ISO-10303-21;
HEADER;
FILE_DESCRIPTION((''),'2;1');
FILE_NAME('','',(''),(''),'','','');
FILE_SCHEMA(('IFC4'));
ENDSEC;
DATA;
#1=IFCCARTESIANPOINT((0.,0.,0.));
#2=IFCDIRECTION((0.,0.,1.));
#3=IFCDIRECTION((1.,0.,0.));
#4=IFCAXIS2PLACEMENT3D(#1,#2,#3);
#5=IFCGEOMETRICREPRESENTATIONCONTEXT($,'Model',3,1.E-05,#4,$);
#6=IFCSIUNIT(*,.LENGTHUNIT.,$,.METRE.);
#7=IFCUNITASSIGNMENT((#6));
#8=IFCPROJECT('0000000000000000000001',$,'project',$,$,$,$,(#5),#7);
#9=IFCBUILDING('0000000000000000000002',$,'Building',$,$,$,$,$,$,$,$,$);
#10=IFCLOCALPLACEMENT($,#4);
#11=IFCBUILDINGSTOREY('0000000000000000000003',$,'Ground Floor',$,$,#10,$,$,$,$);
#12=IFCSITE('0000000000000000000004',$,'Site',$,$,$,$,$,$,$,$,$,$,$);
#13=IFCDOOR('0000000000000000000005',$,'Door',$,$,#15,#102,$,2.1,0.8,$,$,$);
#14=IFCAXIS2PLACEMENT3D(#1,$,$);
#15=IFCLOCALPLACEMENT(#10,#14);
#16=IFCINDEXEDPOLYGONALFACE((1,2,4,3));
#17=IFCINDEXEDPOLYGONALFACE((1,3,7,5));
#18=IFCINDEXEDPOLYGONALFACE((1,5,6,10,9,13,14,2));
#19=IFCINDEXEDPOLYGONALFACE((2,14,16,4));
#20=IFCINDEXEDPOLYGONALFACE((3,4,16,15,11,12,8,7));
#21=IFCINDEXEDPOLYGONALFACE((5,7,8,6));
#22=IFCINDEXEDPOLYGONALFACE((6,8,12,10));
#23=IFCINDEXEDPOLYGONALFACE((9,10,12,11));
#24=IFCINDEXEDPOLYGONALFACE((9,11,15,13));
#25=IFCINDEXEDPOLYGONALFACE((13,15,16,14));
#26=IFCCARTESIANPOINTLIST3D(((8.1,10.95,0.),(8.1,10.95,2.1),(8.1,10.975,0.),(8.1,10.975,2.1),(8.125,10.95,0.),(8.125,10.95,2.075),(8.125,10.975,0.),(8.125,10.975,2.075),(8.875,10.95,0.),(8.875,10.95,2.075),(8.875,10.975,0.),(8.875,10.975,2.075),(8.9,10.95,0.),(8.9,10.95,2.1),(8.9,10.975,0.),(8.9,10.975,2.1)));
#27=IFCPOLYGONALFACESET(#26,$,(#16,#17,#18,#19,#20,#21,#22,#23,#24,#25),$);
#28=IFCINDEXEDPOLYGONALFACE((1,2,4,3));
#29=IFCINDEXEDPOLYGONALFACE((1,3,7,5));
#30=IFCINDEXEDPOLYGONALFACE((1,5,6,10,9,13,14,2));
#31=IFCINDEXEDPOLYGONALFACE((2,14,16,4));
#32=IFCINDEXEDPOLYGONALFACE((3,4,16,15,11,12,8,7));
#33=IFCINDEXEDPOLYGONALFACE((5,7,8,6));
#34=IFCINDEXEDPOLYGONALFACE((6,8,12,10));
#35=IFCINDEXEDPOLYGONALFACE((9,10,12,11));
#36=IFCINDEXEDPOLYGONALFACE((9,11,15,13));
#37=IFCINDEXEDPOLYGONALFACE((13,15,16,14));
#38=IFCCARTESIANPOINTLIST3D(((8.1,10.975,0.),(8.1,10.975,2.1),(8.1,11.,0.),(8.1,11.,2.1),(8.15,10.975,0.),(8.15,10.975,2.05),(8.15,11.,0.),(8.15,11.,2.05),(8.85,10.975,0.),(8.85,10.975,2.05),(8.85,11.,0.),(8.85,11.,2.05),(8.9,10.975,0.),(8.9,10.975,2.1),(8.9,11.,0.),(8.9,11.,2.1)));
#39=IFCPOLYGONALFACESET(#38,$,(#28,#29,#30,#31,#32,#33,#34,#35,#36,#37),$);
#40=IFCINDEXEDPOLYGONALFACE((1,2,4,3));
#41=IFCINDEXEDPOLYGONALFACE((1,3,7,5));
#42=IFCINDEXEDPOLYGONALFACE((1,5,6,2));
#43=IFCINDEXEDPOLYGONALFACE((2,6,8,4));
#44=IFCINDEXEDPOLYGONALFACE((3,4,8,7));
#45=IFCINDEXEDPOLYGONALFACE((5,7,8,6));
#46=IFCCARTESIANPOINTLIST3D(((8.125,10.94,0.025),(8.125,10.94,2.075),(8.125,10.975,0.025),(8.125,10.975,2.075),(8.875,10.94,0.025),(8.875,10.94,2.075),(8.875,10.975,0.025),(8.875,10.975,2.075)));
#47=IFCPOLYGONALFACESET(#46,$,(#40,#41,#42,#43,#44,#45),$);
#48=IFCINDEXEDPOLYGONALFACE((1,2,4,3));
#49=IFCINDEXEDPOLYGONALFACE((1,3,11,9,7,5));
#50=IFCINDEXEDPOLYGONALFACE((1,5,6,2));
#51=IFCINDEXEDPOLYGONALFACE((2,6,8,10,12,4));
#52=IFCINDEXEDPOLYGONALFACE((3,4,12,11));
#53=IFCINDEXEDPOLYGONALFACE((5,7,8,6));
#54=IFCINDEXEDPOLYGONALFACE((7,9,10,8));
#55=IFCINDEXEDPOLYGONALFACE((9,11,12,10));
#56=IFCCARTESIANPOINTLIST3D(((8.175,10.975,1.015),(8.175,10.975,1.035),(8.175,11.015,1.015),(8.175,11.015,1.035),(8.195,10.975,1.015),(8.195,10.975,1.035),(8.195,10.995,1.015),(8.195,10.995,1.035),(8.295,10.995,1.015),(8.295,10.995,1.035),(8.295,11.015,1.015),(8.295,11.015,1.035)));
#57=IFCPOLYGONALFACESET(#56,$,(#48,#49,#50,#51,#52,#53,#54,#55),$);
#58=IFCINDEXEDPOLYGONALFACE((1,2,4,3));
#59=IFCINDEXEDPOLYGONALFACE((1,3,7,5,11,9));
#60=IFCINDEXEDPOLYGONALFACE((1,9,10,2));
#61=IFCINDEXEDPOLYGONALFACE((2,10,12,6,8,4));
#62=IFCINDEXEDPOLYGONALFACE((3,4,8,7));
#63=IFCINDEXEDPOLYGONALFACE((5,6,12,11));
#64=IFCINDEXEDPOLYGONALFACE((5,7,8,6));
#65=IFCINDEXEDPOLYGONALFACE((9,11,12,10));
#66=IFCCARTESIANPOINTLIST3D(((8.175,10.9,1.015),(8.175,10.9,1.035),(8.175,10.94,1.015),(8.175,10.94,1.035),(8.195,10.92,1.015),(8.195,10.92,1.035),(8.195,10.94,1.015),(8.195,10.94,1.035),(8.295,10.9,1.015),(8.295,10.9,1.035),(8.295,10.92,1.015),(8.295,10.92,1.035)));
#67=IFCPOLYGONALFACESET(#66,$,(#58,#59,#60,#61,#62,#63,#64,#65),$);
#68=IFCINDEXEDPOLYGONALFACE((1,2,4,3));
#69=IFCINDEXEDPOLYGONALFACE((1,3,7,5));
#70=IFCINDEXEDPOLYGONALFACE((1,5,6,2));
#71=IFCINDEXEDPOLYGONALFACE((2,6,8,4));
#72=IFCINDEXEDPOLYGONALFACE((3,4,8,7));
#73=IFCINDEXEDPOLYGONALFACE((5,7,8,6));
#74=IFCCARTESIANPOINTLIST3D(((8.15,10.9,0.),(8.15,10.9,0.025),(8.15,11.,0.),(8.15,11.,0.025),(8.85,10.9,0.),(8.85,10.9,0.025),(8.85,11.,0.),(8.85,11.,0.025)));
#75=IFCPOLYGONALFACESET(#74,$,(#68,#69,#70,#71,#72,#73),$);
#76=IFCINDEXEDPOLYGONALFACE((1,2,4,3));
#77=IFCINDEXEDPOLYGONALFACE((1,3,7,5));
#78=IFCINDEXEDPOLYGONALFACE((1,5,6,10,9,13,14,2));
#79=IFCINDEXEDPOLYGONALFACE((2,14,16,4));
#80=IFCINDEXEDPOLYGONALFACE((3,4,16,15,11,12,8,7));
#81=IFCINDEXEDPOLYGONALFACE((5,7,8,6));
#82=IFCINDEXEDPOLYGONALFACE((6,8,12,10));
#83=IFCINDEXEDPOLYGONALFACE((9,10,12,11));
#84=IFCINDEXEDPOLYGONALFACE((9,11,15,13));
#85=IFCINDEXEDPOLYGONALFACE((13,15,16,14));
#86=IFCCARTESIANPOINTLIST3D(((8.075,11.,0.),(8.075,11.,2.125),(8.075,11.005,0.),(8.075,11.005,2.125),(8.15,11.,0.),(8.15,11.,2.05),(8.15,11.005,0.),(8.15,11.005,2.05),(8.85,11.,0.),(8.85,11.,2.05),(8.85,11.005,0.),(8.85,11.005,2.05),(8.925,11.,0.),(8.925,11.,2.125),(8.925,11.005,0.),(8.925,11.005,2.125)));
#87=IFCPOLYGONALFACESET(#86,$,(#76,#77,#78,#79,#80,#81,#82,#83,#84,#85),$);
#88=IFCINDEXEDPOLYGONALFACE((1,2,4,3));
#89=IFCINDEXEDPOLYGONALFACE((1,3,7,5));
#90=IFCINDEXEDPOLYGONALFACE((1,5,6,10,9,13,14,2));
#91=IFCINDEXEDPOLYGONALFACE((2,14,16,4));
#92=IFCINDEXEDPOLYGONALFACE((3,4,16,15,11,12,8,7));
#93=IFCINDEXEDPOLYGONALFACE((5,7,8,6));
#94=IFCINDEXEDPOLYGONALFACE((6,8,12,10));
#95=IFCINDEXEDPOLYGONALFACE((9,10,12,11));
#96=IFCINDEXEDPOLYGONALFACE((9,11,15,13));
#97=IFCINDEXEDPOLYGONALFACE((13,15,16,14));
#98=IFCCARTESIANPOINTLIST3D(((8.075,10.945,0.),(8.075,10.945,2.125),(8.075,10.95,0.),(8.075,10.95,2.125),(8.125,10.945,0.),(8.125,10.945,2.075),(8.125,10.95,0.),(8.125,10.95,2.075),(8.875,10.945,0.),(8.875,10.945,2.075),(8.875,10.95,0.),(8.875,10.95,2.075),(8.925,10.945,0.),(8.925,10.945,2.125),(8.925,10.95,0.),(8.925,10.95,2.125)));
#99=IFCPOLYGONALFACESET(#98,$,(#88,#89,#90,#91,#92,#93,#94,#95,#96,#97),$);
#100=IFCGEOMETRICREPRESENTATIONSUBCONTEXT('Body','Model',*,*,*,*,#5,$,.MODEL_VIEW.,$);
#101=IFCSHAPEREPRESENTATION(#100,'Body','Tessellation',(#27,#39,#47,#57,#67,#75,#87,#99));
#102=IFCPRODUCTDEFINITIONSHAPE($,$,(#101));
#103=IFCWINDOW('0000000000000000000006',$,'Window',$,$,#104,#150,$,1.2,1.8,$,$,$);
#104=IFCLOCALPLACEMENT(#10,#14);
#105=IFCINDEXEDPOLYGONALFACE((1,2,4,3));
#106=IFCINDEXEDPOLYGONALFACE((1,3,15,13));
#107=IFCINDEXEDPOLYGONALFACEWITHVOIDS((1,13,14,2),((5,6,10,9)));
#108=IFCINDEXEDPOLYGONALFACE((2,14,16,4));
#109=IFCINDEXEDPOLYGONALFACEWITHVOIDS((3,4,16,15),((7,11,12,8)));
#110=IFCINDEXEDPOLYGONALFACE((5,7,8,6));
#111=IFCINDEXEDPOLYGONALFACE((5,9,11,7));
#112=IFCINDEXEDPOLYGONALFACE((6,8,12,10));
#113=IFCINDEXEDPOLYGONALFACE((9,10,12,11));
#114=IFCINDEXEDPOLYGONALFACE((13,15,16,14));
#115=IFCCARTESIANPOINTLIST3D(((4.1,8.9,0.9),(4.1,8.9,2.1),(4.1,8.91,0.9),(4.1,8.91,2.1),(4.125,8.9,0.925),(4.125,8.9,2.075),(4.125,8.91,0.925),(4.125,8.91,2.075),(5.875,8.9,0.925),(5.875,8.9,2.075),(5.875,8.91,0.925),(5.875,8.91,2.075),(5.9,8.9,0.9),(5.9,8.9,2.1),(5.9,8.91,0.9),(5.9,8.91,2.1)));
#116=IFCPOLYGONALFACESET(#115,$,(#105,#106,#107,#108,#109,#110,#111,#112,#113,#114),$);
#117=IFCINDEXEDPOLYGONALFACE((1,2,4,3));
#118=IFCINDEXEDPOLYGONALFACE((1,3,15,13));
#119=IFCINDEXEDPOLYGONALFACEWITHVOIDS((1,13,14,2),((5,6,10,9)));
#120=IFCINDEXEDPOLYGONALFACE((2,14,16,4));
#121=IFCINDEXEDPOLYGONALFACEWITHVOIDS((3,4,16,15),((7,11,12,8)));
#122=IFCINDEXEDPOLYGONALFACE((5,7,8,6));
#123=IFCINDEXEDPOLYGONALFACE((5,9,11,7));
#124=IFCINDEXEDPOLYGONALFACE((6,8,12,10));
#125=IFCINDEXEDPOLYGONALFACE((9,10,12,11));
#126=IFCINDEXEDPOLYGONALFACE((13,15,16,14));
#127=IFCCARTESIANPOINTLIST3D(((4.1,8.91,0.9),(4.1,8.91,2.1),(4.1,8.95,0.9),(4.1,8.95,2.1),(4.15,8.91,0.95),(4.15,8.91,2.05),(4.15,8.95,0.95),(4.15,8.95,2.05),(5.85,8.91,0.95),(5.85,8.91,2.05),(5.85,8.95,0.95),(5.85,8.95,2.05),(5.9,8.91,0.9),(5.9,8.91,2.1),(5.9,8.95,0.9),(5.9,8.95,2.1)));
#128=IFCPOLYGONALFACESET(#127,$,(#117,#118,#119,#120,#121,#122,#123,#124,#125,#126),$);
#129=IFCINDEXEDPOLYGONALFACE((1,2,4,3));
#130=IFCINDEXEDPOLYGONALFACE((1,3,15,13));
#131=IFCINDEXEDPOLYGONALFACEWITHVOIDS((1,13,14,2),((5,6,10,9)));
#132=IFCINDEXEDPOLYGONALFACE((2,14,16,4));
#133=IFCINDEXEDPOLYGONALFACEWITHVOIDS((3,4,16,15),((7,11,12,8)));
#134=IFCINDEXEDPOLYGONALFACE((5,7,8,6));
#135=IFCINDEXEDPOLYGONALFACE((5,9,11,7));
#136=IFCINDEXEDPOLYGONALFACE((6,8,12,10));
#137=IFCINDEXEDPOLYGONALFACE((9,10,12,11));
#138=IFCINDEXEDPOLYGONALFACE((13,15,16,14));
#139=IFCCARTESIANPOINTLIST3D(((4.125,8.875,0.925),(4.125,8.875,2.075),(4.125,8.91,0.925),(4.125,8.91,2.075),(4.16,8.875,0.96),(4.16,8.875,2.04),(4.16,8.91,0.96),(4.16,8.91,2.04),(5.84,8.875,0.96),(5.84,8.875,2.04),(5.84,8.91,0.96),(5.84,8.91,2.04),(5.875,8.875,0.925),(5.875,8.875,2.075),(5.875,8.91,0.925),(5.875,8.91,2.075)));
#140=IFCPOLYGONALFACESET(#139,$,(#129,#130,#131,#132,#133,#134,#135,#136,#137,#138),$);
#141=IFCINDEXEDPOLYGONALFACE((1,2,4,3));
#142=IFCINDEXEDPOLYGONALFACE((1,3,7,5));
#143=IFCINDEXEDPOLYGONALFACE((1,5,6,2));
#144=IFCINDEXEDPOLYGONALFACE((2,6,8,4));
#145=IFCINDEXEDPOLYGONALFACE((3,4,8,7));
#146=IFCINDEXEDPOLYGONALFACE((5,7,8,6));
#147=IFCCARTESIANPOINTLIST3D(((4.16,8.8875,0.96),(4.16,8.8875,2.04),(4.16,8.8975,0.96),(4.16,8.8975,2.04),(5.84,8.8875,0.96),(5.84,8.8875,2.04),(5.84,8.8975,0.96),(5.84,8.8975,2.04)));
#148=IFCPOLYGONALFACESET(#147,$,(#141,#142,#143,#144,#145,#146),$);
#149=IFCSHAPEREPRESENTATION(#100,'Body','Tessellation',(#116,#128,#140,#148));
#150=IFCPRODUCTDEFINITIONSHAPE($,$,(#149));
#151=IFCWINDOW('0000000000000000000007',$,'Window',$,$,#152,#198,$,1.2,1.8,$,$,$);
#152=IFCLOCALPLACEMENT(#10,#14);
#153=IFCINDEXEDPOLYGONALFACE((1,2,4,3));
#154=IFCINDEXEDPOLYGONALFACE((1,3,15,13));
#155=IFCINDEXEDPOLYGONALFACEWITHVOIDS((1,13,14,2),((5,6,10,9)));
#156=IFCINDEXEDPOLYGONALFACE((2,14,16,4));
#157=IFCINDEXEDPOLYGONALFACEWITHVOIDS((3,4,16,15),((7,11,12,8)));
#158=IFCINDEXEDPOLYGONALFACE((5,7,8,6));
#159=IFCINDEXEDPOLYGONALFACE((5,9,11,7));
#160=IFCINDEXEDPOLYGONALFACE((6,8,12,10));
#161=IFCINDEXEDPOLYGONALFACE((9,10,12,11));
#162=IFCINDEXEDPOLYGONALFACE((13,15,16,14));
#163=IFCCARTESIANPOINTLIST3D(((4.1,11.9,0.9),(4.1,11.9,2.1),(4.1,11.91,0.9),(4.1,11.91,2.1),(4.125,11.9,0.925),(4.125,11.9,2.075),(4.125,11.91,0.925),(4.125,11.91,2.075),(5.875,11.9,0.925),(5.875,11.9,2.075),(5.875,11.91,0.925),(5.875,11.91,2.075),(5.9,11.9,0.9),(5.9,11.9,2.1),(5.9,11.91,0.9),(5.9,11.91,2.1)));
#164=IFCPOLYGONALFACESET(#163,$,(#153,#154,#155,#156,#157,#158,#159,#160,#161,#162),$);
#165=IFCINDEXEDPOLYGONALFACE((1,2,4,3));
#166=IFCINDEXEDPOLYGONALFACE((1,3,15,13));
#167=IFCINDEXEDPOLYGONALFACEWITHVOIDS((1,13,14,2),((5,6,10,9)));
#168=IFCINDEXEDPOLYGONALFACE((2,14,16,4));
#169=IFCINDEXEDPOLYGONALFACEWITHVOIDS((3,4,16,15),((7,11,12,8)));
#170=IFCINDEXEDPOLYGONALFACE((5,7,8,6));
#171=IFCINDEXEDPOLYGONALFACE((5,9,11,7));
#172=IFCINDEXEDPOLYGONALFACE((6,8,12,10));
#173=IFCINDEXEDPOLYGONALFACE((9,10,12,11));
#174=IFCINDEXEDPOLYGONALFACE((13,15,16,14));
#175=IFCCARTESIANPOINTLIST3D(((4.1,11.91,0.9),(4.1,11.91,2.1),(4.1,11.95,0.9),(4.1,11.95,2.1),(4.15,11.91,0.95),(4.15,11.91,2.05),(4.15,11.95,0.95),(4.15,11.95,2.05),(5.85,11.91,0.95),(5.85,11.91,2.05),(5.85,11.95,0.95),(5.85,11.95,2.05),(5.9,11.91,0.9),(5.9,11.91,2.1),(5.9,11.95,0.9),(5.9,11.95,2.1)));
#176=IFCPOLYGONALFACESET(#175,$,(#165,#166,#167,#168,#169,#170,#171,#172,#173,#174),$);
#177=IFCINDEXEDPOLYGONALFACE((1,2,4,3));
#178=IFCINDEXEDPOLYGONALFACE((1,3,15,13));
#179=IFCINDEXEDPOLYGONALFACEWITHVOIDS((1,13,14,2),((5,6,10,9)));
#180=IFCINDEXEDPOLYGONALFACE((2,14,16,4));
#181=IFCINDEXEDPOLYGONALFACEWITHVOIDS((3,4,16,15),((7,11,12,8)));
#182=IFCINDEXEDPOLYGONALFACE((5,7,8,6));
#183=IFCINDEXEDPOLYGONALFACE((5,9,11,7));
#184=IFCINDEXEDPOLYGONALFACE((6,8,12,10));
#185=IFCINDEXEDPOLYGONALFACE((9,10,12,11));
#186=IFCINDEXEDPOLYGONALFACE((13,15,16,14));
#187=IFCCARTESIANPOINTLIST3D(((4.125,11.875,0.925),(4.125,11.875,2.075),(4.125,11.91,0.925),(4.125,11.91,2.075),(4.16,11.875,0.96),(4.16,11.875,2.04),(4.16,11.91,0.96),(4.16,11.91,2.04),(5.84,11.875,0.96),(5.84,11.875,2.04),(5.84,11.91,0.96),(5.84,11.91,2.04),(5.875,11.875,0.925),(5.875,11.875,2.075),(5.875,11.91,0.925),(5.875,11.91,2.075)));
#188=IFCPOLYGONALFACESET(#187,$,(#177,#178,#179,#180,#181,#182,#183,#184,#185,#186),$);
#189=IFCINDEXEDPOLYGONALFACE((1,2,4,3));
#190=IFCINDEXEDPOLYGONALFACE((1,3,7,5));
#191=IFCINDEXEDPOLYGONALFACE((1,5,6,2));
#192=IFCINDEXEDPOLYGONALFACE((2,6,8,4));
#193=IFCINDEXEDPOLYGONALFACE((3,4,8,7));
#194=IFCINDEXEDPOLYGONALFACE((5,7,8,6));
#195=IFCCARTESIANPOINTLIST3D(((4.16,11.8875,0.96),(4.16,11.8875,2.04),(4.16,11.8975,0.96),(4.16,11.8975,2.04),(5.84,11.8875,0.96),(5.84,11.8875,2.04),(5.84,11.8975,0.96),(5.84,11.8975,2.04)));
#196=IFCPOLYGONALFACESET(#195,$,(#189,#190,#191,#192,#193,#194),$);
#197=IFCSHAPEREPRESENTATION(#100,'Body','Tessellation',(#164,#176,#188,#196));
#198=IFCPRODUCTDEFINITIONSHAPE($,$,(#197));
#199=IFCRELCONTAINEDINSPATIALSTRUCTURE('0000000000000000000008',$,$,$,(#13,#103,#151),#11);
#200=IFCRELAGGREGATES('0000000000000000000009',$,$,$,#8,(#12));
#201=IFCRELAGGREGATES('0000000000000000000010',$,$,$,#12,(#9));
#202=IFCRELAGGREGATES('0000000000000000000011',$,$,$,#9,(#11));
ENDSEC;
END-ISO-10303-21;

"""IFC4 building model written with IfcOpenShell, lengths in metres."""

from ifc_helpers import new_model, si_unit, frame, origin_with_axes, place, context, subcontext, project, spatial, line, indexed_curve, outline, extrude, element, save


model = new_model("IFC4")

# Units and contexts
model_context = context("Model", 3, precision=1e-05, world=origin_with_axes())
body_context = subcontext(model_context, "Body", "Model", "MODEL_VIEW")
ifc_project = project(units=[si_unit("LENGTHUNIT", "METRE")], contexts=[model_context])

# Site, building, storey
site = spatial("IfcSite", under=ifc_project, Name="Site")
building = spatial("IfcBuilding", under=site, Name="Building")
storey_placement = place(None, origin_with_axes())
storey = spatial("IfcBuildingStorey", under=building, at=storey_placement, Name="Ground Floor")

# Door
door_1_placement = place(storey_placement, frame((8.9, 11.0, 0.0), z_axis=(0.0, 0.0, 1.0), x_axis=(-1.0, 0.0, 0.0)))
element("IfcDoor", 1, at=door_1_placement, inside=storey, Name="Door", OverallHeight=2.1, OverallWidth=0.8, context=body_context, shape_type="SweptSolid", body=[
    extrude(outline(indexed_curve([(0.0, 0.0), (0.0, 2.1), (0.8, 2.1), (0.8, 0.0), (0.775, 0.0), (0.775, 2.075), (0.025, 2.075), (0.025, 0.0)], segments=[line(1, 2, 3, 4, 5, 6, 7, 8, 1)])), frame((0.0, 0.025, 0.0), z_axis=(0.0, -1.0, 0.0), x_axis=(1.0, 0.0, 0.0)), (0.0, 0.0, -1.0), 0.025),
    extrude(outline(indexed_curve([(0.0, 0.0), (0.0, 2.1), (0.8, 2.1), (0.8, 0.0), (0.75, 0.0), (0.75, 2.05), (0.05, 2.05), (0.05, 0.0)], segments=[line(1, 2, 3, 4, 5, 6, 7, 8, 1)])), frame((0.0, 0.0, 0.0), z_axis=(0.0, -1.0, 0.0), x_axis=(1.0, 0.0, 0.0)), (0.0, 0.0, -1.0), 0.025),
    extrude(outline(indexed_curve([(0.0, 0.0), (0.75, 0.0), (0.75, 0.035), (0.0, 0.035)], segments=[line(1, 2, 3, 4, 1)])), frame((0.025, 0.025, 0.025), z_axis=(0.0, 0.0, 1.0), x_axis=(1.0, 0.0, 0.0)), (0.0, 0.0, 1.0), 2.05),
    extrude(outline(indexed_curve([(0.0, 0.0), (0.0, -0.04), (-0.12, -0.04), (-0.12, -0.02), (-0.02, -0.02), (-0.02, 0.0)], segments=[line(1, 2, 3, 4, 5, 6, 1)])), frame((0.725, 0.025, 1.015), z_axis=(0.0, 0.0, 1.0), x_axis=(1.0, 0.0, 0.0)), (0.0, 0.0, 1.0), 0.02),
    extrude(outline(indexed_curve([(0.0, 0.0), (0.0, 0.04), (-0.12, 0.04), (-0.12, 0.02), (-0.02, 0.02), (-0.02, 0.0)], segments=[line(1, 2, 3, 4, 5, 6, 1)])), frame((0.725, 0.06, 1.015), z_axis=(0.0, 0.0, 1.0), x_axis=(1.0, 0.0, 0.0)), (0.0, 0.0, 1.0), 0.02),
    extrude(outline(indexed_curve([(0.0, 0.0), (0.7, 0.0), (0.7, 0.1), (0.0, 0.1)], segments=[line(1, 2, 3, 4, 1)])), frame((0.05, 0.0, 0.0), z_axis=(0.0, 0.0, 1.0), x_axis=(1.0, 0.0, 0.0)), (0.0, 0.0, 1.0), 0.025),
    extrude(outline(indexed_curve([(0.0, 0.0), (0.0, 2.125), (0.85, 2.125), (0.85, 0.0), (0.775, 0.0), (0.775, 2.05), (0.075, 2.05), (0.075, 0.0)], segments=[line(1, 2, 3, 4, 5, 6, 7, 8, 1)])), frame((-0.025, -0.005, 0.0), z_axis=(0.0, -1.0, 0.0), x_axis=(1.0, 0.0, 0.0)), (0.0, 0.0, -1.0), 0.005),
    extrude(outline(indexed_curve([(0.0, 0.0), (0.0, 2.125), (0.85, 2.125), (0.85, 0.0), (0.8, 0.0), (0.8, 2.075), (0.05, 2.075), (0.05, 0.0)], segments=[line(1, 2, 3, 4, 5, 6, 7, 8, 1)])), frame((-0.025, 0.05, 0.0), z_axis=(0.0, -1.0, 0.0), x_axis=(1.0, 0.0, 0.0)), (0.0, 0.0, -1.0), 0.005),
])

# Windows
for number, where, z_axis, x_axis, name in (
    (2, (5.9, 9.0, 0.9), (0.0, 0.0, 1.0), (-1.0, 0.0, 0.0), "Window"),
    (3, (5.9, 12.0, 0.9), (0.0, 0.0, 1.0), (-1.0, 0.0, 0.0), "Window"),
):
    element("IfcWindow", number, at=place(storey_placement, frame(where, z_axis=z_axis, x_axis=x_axis)), inside=storey, Name=name, OverallHeight=1.2, OverallWidth=1.8, context=body_context, shape_type="SweptSolid", body=[
        extrude(outline(indexed_curve([(0.0, 0.0), (1.8, 0.0), (1.8, 1.2), (0.0, 1.2)], segments=[line(1, 2, 3, 4, 1)]), holes=[indexed_curve([(0.025, 0.025), (1.775, 0.025), (1.775, 1.175), (0.025, 1.175)], segments=[line(1, 2, 3, 4, 1)])]), frame((0.0, 0.09, 0.0), z_axis=(0.0, -1.0, 0.0), x_axis=(1.0, 0.0, 0.0)), (0.0, 0.0, -1.0), 0.01),
        extrude(outline(indexed_curve([(0.0, 0.0), (1.8, 0.0), (1.8, 1.2), (0.0, 1.2)], segments=[line(1, 2, 3, 4, 1)]), holes=[indexed_curve([(0.05, 0.05), (1.75, 0.05), (1.75, 1.15), (0.05, 1.15)], segments=[line(1, 2, 3, 4, 1)])]), frame((0.0, 0.05, 0.0), z_axis=(0.0, -1.0, 0.0), x_axis=(1.0, 0.0, 0.0)), (0.0, 0.0, -1.0), 0.04),
        extrude(outline(indexed_curve([(0.0, 0.0), (1.75, 0.0), (1.75, 1.15), (0.0, 1.15)], segments=[line(1, 2, 3, 4, 1)]), holes=[indexed_curve([(0.035, 0.035), (1.715, 0.035), (1.715, 1.115), (0.035, 1.115)], segments=[line(1, 2, 3, 4, 1)])]), frame((0.025, 0.09, 0.025), z_axis=(0.0, -1.0, 0.0), x_axis=(1.0, 0.0, 0.0)), (0.0, 0.0, -1.0), 0.035),
        extrude(outline(indexed_curve([(0.035, 0.035), (1.715, 0.035), (1.715, 1.115), (0.035, 1.115)], segments=[line(1, 2, 3, 4, 1)])), frame((0.025, 0.1025, 0.025), z_axis=(0.0, -1.0, 0.0), x_axis=(1.0, 0.0, 0.0)), (0.0, 0.0, -1.0), 0.01),
    ])

save(model, "model.ifc")
